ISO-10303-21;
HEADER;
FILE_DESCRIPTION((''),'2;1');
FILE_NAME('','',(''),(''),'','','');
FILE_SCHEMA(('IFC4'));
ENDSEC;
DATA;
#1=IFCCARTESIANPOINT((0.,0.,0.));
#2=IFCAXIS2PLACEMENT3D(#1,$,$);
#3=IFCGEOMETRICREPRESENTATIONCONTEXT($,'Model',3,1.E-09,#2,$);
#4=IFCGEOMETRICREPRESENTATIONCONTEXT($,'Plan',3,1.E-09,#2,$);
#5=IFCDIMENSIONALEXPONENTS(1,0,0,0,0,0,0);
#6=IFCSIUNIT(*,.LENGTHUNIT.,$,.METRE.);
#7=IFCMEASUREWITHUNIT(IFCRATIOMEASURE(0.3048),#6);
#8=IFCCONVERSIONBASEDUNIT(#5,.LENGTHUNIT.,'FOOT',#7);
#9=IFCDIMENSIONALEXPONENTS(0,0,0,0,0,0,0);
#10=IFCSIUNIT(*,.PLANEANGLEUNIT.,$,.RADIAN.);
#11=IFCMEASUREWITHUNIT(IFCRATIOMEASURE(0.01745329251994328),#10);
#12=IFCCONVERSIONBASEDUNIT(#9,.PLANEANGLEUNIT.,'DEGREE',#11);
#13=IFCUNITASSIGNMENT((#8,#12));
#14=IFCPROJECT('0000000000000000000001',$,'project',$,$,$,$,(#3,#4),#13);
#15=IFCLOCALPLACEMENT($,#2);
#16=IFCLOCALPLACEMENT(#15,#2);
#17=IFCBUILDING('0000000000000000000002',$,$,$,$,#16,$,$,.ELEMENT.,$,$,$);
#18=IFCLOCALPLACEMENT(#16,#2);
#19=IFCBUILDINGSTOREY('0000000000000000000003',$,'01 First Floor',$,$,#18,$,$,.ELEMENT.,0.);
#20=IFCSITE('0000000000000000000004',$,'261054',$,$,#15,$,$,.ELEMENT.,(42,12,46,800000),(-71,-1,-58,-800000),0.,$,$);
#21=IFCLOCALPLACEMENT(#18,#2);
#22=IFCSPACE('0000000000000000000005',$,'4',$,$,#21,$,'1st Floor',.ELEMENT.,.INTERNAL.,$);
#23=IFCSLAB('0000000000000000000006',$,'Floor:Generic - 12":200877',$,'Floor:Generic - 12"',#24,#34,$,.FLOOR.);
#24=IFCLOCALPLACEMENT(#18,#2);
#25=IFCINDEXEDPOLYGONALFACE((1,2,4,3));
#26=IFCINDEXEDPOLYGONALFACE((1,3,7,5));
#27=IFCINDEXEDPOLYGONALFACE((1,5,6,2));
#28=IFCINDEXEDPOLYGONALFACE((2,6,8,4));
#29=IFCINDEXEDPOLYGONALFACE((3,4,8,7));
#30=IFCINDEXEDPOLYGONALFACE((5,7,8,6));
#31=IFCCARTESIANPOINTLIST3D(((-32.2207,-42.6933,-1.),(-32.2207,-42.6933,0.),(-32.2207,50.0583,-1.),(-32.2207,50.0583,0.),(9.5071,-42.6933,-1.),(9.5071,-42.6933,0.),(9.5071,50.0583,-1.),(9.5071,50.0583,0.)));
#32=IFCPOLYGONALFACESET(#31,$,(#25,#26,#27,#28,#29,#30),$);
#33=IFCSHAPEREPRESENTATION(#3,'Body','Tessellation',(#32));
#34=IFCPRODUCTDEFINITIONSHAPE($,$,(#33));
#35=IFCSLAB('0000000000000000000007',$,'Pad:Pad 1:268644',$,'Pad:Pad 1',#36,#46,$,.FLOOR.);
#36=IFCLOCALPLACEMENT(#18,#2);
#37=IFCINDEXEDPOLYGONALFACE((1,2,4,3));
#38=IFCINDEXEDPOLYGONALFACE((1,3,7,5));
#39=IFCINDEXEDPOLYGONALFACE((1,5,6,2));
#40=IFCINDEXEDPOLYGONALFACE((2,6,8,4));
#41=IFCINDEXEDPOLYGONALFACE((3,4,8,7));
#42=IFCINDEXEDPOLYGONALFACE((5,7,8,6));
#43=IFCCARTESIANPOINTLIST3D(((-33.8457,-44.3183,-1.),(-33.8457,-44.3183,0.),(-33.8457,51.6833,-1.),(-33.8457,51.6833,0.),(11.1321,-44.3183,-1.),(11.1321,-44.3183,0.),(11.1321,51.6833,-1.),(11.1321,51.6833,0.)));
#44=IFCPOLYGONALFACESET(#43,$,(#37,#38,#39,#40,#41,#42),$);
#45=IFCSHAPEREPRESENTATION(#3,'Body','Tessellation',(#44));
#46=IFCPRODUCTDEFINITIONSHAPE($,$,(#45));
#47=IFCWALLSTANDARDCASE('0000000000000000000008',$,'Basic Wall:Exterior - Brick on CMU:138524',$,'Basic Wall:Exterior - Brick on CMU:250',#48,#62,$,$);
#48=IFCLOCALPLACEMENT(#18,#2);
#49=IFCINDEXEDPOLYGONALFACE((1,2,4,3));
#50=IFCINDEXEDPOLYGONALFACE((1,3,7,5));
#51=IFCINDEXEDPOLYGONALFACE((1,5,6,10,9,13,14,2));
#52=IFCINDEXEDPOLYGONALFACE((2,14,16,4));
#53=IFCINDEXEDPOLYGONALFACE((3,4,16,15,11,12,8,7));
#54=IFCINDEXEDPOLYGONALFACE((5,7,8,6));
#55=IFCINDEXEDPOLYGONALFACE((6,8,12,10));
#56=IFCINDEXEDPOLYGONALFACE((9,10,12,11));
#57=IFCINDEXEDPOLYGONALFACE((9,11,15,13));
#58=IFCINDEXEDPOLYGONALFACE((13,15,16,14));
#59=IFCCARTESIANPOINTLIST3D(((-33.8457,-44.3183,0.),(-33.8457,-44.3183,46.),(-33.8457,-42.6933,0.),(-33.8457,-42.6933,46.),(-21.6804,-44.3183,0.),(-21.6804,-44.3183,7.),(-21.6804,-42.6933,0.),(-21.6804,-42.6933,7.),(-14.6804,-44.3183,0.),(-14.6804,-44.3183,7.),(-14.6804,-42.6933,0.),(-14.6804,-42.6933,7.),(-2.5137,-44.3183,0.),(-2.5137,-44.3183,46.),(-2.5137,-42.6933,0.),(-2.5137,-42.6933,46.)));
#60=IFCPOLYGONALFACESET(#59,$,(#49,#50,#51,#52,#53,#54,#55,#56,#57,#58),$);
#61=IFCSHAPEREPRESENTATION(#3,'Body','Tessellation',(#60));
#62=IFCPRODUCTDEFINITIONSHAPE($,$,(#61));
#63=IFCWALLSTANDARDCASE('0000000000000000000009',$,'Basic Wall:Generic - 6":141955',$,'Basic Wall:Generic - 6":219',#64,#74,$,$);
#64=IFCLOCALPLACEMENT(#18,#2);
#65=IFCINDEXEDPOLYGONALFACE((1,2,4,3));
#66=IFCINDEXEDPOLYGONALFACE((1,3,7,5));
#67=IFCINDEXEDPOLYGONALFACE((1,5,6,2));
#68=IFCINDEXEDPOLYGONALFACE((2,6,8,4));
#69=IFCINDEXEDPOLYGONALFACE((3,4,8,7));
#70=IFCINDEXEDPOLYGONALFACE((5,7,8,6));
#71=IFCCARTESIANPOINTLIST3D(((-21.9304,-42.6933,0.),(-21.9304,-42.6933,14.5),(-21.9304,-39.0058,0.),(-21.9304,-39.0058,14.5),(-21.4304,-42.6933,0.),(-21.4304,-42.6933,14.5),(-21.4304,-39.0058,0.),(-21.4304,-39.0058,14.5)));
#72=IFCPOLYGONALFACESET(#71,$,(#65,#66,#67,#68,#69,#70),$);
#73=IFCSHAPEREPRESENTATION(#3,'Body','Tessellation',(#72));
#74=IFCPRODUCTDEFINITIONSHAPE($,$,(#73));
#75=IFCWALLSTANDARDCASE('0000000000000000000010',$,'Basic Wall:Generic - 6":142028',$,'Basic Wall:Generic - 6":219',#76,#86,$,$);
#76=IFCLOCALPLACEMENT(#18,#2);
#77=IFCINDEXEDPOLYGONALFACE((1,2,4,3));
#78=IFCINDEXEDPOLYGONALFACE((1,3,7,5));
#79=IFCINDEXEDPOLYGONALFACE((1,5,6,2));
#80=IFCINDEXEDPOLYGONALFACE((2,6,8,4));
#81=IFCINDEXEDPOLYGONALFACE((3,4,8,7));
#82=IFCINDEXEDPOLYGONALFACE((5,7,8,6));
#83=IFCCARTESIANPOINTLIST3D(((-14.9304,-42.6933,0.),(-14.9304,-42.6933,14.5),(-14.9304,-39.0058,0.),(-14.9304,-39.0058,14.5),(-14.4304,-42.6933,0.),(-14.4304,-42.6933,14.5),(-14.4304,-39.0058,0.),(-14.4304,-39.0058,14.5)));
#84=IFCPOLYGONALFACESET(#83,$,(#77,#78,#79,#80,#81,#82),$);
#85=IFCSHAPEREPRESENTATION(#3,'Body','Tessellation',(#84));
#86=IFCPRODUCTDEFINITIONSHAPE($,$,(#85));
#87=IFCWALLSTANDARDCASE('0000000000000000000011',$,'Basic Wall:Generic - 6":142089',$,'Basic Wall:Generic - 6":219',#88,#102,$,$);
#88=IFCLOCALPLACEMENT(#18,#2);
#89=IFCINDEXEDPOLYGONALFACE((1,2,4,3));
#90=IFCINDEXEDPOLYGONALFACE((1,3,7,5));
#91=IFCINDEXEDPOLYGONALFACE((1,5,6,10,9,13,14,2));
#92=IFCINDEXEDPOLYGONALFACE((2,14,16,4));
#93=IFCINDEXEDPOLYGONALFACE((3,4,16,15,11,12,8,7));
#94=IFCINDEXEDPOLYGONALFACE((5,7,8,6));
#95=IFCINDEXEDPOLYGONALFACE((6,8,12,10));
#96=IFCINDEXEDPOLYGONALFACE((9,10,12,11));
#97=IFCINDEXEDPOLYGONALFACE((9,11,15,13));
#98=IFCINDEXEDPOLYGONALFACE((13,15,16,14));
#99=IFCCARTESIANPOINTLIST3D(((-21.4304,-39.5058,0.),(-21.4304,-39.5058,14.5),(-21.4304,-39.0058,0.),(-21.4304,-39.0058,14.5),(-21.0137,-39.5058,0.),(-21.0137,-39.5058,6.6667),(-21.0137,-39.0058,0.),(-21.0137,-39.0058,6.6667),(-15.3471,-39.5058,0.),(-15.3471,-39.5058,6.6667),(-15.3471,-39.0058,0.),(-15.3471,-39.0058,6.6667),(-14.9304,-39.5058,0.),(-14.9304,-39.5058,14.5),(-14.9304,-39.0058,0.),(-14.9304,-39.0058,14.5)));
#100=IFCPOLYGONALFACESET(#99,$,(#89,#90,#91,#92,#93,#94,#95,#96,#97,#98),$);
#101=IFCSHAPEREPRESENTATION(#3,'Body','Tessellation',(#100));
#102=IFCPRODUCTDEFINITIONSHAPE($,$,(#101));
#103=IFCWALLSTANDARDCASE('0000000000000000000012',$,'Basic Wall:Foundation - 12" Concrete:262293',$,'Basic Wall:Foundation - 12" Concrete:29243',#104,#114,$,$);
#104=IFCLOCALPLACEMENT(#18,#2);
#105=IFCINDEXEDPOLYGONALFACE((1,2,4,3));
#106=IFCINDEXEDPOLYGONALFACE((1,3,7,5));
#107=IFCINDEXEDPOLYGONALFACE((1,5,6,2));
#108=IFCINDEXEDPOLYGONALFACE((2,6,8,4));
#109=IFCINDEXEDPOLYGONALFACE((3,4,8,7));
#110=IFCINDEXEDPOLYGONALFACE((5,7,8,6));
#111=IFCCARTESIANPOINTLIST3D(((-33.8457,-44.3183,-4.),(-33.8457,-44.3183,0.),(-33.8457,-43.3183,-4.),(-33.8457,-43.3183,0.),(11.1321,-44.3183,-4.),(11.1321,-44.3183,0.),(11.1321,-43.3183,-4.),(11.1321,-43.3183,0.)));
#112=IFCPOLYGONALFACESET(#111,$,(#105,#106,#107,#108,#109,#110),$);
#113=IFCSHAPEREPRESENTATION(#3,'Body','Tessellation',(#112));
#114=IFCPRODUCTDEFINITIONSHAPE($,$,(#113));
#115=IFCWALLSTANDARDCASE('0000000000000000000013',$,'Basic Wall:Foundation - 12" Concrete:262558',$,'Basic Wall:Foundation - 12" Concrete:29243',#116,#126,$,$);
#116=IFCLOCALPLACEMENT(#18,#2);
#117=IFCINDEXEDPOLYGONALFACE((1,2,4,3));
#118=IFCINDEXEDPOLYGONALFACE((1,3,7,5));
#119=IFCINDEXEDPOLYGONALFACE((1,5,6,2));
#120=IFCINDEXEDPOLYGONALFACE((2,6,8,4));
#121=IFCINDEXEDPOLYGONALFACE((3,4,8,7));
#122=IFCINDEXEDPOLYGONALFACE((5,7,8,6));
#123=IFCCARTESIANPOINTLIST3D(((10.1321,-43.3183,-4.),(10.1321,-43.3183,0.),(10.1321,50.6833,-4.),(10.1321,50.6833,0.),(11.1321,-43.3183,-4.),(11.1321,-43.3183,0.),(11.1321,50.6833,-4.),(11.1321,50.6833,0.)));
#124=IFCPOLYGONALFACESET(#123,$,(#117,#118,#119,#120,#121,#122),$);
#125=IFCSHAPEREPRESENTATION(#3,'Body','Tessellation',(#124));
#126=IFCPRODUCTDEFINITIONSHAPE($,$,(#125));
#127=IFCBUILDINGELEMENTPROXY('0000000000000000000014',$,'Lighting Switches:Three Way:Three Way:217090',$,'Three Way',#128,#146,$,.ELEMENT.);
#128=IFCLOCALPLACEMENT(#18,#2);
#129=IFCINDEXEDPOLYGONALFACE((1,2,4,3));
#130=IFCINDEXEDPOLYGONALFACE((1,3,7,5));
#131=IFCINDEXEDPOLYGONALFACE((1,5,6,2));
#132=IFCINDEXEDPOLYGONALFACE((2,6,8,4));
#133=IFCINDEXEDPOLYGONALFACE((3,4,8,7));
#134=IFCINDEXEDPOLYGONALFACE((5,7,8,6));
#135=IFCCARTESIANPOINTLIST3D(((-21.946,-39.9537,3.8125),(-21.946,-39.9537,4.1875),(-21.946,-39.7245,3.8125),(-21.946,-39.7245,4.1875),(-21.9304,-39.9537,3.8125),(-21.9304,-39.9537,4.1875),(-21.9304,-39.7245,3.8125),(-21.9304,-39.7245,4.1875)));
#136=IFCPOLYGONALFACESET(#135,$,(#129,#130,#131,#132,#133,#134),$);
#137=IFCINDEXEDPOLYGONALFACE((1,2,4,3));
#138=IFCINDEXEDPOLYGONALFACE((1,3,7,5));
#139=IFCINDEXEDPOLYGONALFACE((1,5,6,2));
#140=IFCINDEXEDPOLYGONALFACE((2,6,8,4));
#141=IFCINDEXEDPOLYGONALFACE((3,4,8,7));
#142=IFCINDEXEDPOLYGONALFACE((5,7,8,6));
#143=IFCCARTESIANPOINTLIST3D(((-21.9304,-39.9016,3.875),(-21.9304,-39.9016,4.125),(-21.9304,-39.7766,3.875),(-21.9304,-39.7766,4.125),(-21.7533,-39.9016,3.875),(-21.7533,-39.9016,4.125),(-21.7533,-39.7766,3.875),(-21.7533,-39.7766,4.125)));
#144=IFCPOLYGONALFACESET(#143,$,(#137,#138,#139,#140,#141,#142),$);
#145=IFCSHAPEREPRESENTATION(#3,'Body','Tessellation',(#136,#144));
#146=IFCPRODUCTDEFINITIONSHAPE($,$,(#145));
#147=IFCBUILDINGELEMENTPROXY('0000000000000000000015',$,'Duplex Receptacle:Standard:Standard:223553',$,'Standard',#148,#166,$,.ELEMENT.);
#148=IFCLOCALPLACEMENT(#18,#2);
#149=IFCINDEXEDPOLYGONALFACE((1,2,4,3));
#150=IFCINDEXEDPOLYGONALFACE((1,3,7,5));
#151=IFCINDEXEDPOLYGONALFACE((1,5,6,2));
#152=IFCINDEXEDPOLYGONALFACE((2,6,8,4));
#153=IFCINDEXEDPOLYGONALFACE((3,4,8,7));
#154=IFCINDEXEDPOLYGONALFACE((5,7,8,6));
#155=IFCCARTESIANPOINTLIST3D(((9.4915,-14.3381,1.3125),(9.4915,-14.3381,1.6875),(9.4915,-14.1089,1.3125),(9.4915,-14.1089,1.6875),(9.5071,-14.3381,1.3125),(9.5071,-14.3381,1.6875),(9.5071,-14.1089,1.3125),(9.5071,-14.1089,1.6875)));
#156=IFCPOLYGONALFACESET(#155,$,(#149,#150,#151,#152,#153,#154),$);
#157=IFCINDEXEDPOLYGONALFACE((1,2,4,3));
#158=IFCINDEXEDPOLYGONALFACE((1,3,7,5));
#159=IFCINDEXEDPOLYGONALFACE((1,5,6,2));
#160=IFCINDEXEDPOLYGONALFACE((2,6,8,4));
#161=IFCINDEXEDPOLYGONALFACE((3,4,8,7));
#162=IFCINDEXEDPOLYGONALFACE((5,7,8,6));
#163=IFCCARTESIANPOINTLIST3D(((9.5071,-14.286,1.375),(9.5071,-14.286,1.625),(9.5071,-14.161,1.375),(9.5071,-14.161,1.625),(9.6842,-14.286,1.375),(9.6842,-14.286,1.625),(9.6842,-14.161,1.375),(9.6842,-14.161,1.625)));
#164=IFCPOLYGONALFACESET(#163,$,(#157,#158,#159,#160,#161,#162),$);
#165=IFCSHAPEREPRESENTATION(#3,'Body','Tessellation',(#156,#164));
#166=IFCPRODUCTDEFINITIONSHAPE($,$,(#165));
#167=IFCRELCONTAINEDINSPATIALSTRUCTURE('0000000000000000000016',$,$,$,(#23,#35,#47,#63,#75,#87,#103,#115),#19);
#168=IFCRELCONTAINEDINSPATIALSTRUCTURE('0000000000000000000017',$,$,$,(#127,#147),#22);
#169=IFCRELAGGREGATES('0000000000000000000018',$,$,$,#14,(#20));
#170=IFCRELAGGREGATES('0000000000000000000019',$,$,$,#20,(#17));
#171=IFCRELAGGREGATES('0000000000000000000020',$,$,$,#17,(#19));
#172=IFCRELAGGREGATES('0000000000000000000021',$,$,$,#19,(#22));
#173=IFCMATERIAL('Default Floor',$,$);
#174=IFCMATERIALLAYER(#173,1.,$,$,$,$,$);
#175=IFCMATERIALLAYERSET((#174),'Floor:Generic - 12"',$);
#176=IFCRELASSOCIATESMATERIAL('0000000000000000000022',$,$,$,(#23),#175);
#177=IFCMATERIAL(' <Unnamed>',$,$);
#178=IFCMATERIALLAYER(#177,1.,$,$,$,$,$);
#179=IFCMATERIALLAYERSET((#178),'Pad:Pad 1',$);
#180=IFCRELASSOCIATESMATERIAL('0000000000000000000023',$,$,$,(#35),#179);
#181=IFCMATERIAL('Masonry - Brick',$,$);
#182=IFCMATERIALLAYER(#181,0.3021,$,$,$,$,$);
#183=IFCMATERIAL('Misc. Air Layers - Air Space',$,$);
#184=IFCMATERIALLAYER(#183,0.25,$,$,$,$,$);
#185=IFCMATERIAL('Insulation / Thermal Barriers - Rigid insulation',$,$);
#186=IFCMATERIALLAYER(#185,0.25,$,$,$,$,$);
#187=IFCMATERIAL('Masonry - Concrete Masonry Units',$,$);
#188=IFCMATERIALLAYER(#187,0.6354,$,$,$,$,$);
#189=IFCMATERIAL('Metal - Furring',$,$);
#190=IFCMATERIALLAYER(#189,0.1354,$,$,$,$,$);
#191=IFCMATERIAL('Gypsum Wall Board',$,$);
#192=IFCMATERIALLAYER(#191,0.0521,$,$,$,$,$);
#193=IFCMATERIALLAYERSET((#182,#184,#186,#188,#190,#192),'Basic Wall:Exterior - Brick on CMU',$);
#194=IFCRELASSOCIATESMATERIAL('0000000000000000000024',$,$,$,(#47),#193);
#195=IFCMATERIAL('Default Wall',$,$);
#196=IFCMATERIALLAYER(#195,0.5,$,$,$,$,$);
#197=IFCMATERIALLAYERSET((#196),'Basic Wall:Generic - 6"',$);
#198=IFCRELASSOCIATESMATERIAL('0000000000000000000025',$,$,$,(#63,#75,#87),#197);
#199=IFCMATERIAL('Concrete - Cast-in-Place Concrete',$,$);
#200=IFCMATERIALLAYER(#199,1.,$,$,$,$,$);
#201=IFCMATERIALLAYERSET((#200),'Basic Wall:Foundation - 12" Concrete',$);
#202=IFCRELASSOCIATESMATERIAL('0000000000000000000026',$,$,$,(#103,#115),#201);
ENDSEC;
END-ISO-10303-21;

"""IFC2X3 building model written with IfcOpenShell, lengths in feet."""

from ifc_helpers import new_model, entity, si_unit, converted_unit, frame, frame_2d, origin, origin_2d_with_axis, place, context, project, spatial, polyline, rectangle, extrude, clip, bounded_halfspace, source, transform, mapped, material, layer, layer_set, layer_usage, element, save


model = new_model("IFC2X3")

# Units and contexts
model_context = context("Model", 3, precision=1e-09, world=origin())
plan_context = context("Plan", 3, precision=1e-09, world=origin())
ifc_project = project(units=[converted_unit("LENGTHUNIT", "FOOT", entity("IfcRatioMeasure", 0.3048), si_unit("LENGTHUNIT", "METRE"), dimensions=[1, 0, 0, 0, 0, 0, 0]), converted_unit("PLANEANGLEUNIT", "DEGREE", entity("IfcRatioMeasure", 0.01745329251994328), si_unit("PLANEANGLEUNIT", "RADIAN"), dimensions=[0, 0, 0, 0, 0, 0, 0])], contexts=[model_context, plan_context])

# Site, building, storey
site_placement = place(None, origin())
site = spatial("IfcSite", under=ifc_project, at=site_placement, Name="261054", CompositionType="ELEMENT", RefLatitude=(42, 12, 46, 800000), RefLongitude=(-71, -1, -58, -800000), RefElevation=0.0)
building_placement = place(site_placement, origin())
building = spatial("IfcBuilding", under=site, at=building_placement, CompositionType="ELEMENT")
storey_placement = place(building_placement, origin())
storey = spatial("IfcBuildingStorey", under=building, at=storey_placement, Name="01 First Floor", CompositionType="ELEMENT", Elevation=0.0)

# Slabs
ifc_material_1 = material(Name="Default Floor")
ifc_layer_1 = layer(ifc_material_1, 1.0)
ifc_layer_set_1 = layer_set([ifc_layer_1], Name="Floor:Generic - 12\"")
ifc_layer_usage_1 = layer_usage(ifc_layer_set_1, "AXIS3", "POSITIVE", 0.0)
slab_1_placement = place(storey_placement, frame((-32.2207, -42.6933, -1.0)))
element("IfcSlab", 1, at=slab_1_placement, inside=storey, material=ifc_layer_usage_1, Name="Floor:Generic - 12\":200877", ObjectType="Floor:Generic - 12\"", PredefinedType="FLOOR", context=model_context, shape_type="SweptSolid", body=[
    extrude(rectangle(XDim=92.7515, YDim=41.7278, at=frame_2d((0.0, 0.0), x_axis=(0.0, 1.0))), frame((20.8639, 46.3758, 1.0), z_axis=(0.0, 0.0, -1.0), x_axis=(-1.0, 0.0, 0.0)), (0.0, 0.0, 1.0), 1.0),
])
ifc_material_2 = material(Name=" <Unnamed>")
ifc_layer_2 = layer(ifc_material_2, 1.0)
ifc_layer_set_2 = layer_set([ifc_layer_2], Name="Pad:Pad 1")
ifc_layer_usage_2 = layer_usage(ifc_layer_set_2, "AXIS3", "NEGATIVE", 0.0)
slab_2_placement = place(storey_placement, frame((-33.8457, -44.3183, -1.0)))
element("IfcSlab", 2, at=slab_2_placement, inside=storey, material=ifc_layer_usage_2, Name="Pad:Pad 1:268644", ObjectType="Pad:Pad 1", PredefinedType="FLOOR", context=model_context, shape_type="SweptSolid", body=[
    extrude(rectangle(XDim=96.0015, YDim=44.9778, at=frame_2d((0.0, 0.0), x_axis=(0.0, 1.0))), frame((22.4889, 48.0008, 1.0), z_axis=(0.0, 0.0, -1.0), x_axis=(-1.0, 0.0, 0.0)), (0.0, 0.0, 1.0), 1.0),
])

# Wall, opening
ifc_material_3 = material(Name="Masonry - Brick")
ifc_layer_3 = layer(ifc_material_3, 0.3021)
ifc_material_4 = material(Name="Misc. Air Layers - Air Space")
ifc_layer_4 = layer(ifc_material_4, 0.25)
ifc_material_5 = material(Name="Insulation / Thermal Barriers - Rigid insulation")
ifc_layer_5 = layer(ifc_material_5, 0.25)
ifc_material_6 = material(Name="Masonry - Concrete Masonry Units")
ifc_layer_6 = layer(ifc_material_6, 0.6354)
ifc_material_7 = material(Name="Metal - Furring")
ifc_layer_7 = layer(ifc_material_7, 0.1354)
ifc_material_8 = material(Name="Gypsum Wall Board")
ifc_layer_8 = layer(ifc_material_8, 0.0521)
ifc_layer_set_3 = layer_set([ifc_layer_3, ifc_layer_4, ifc_layer_5, ifc_layer_6, ifc_layer_7, ifc_layer_8], Name="Basic Wall:Exterior - Brick on CMU")
ifc_layer_usage_3 = layer_usage(ifc_layer_set_3, "AXIS2", "POSITIVE", -0.8125)
wall_1_placement = place(storey_placement, frame((-33.8457, -43.5058, 0.0)))
wall_1 = element("IfcWallStandardCase", 3, at=wall_1_placement, inside=storey, material=ifc_layer_usage_3, Name="Basic Wall:Exterior - Brick on CMU:138524", ObjectType="Basic Wall:Exterior - Brick on CMU:250", context=model_context, shape_type="SweptSolid", body=[
    extrude(rectangle(XDim=31.332, YDim=1.625, at=frame_2d((15.666, 0.0), x_axis=(-1.0, 0.0))), origin(), (0.0, 0.0, 1.0), 46.0),
])
opening_1_placement = place(wall_1_placement, origin())
element("IfcOpeningElement", 4, at=opening_1_placement, cuts=wall_1, ObjectType="Opening", context=model_context, shape_type="SweptSolid", body=[
    extrude(rectangle(XDim=7.0, YDim=7.0, at=origin_2d_with_axis()), frame((15.6653, -0.8125, 3.5), z_axis=(0.0, 1.0, 0.0), x_axis=(0.0, 0.0, -1.0)), (0.0, 0.0, 1.0), 1.625),
])

# Walls
ifc_material_9 = material(Name="Default Wall")
ifc_layer_9 = layer(ifc_material_9, 0.5)
ifc_layer_set_4 = layer_set([ifc_layer_9], Name="Basic Wall:Generic - 6\"")
ifc_layer_usage_4 = layer_usage(ifc_layer_set_4, "AXIS2", "NEGATIVE", 0.25)
wall_2_placement = place(storey_placement, frame((-21.6804, -42.6933, 0.0), z_axis=(0.0, 0.0, 1.0), x_axis=(0.0, 1.0, 0.0)))
element("IfcWallStandardCase", 5, at=wall_2_placement, inside=storey, material=ifc_layer_usage_4, Name="Basic Wall:Generic - 6\":141955", ObjectType="Basic Wall:Generic - 6\":219", context=model_context, shape_type="Clipping", body=[
    clip(extrude(rectangle(XDim=3.6875, YDim=0.5, at=frame_2d((1.8438, 0.0), x_axis=(-1.0, 0.0))), origin(), (0.0, 0.0, 1.0), 14.5), bounded_halfspace(frame((0.0, -0.25, 14.5), z_axis=(0.0, 0.0, -1.0), x_axis=(-1.0, 0.0, 0.0)), True, frame((0.0, -0.25, 14.5)), polyline([(0.0, 0.0), (3.1875, 0.0), (3.6875, 0.0), (3.6875, 0.5), (0.0, 0.5), (0.0, 0.0)]))),
])
ifc_layer_usage_5 = layer_usage(ifc_layer_set_4, "AXIS2", "NEGATIVE", 0.25)
wall_3_placement = place(storey_placement, frame((-14.6804, -39.0058, 0.0), z_axis=(0.0, 0.0, 1.0), x_axis=(0.0, -1.0, 0.0)))
element("IfcWallStandardCase", 6, at=wall_3_placement, inside=storey, material=ifc_layer_usage_5, Name="Basic Wall:Generic - 6\":142028", ObjectType="Basic Wall:Generic - 6\":219", context=model_context, shape_type="Clipping", body=[
    clip(extrude(rectangle(XDim=3.6875, YDim=0.5, at=frame_2d((1.8438, 0.0), x_axis=(-1.0, 0.0))), origin(), (0.0, 0.0, 1.0), 14.5), bounded_halfspace(frame((0.0, -0.25, 14.5), z_axis=(0.0, 0.0, -1.0), x_axis=(1.0, 0.0, 0.0)), True, frame((0.0, -0.25, 14.5)), polyline([(0.0, 0.0), (0.5, 0.0), (3.6875, 0.0), (3.6875, 0.5), (0.0, 0.5), (0.0, 0.0)]))),
])

# Wall, opening
ifc_layer_usage_6 = layer_usage(ifc_layer_set_4, "AXIS2", "NEGATIVE", 0.25)
wall_4_placement = place(storey_placement, frame((-21.4304, -39.2558, 0.0)))
wall_4 = element("IfcWallStandardCase", 7, at=wall_4_placement, inside=storey, material=ifc_layer_usage_6, Name="Basic Wall:Generic - 6\":142089", ObjectType="Basic Wall:Generic - 6\":219", context=model_context, shape_type="Clipping", body=[
    clip(extrude(rectangle(XDim=6.5, YDim=0.5, at=frame_2d((3.25, 0.0), x_axis=(-1.0, 0.0))), origin(), (0.0, 0.0, 1.0), 14.5), bounded_halfspace(frame((0.0, -0.25, 14.5), z_axis=(0.0, 0.0, -1.0), x_axis=(0.0, -1.0, 0.0)), True, frame((0.0, -0.25, 14.5)), polyline([(0.0, 0.0), (6.5, 0.0), (6.5, 0.5), (0.0, 0.5), (0.0, 0.0)]))),
])
opening_2_placement = place(wall_4_placement, frame((6.0833, 0.25, 0.0)))
element("IfcOpeningElement", 8, at=opening_2_placement, cuts=wall_4, ObjectType="Opening", context=model_context, shape_type="SweptSolid", body=[
    extrude(rectangle(XDim=6.6667, YDim=5.6667, at=frame_2d((3.3333, 2.8333), x_axis=(1.0, 0.0))), frame((0.0, 0.0, 0.0), z_axis=(0.0, -1.0, 0.0), x_axis=(0.0, 0.0, 1.0)), (0.0, 0.0, 1.0), 0.5),
])

# Walls
ifc_material_10 = material(Name="Concrete - Cast-in-Place Concrete")
ifc_layer_10 = layer(ifc_material_10, 1.0)
ifc_layer_set_5 = layer_set([ifc_layer_10], Name="Basic Wall:Foundation - 12\" Concrete")
ifc_layer_usage_7 = layer_usage(ifc_layer_set_5, "AXIS2", "NEGATIVE", 0.5)
wall_5_placement = place(storey_placement, frame((11.1321, -43.8183, -4.0), z_axis=(0.0, 0.0, 1.0), x_axis=(-1.0, 0.0, 0.0)))
element("IfcWallStandardCase", 9, at=wall_5_placement, inside=storey, material=ifc_layer_usage_7, Name="Basic Wall:Foundation - 12\" Concrete:262293", ObjectType="Basic Wall:Foundation - 12\" Concrete:29243", context=model_context, shape_type="SweptSolid", body=[
    extrude(rectangle(XDim=44.9778, YDim=1.0, at=frame_2d((22.4889, 0.0), x_axis=(-1.0, 0.0))), origin(), (0.0, 0.0, 1.0), 4.0),
])
ifc_layer_usage_8 = layer_usage(ifc_layer_set_5, "AXIS2", "NEGATIVE", 0.5)
wall_6_placement = place(storey_placement, frame((10.6321, -43.3183, -4.0), z_axis=(0.0, 0.0, 1.0), x_axis=(0.0, 1.0, 0.0)))
element("IfcWallStandardCase", 10, at=wall_6_placement, inside=storey, material=ifc_layer_usage_8, Name="Basic Wall:Foundation - 12\" Concrete:262558", ObjectType="Basic Wall:Foundation - 12\" Concrete:29243", context=model_context, shape_type="SweptSolid", body=[
    extrude(rectangle(XDim=94.0015, YDim=1.0, at=frame_2d((47.0008, 0.0), x_axis=(-1.0, 0.0))), origin(), (0.0, 0.0, 1.0), 4.0),
])

# Shared definitions
space_placement = place(storey_placement, origin())
space = spatial("IfcSpace", under=storey, at=space_placement, Name="4", LongName="1st Floor", CompositionType="ELEMENT", InteriorOrExteriorSpace="INTERNAL")

# Building element proxies
shared_shape_1 = source(origin(), model_context, "Body", "SweptSolid", [
    extrude(rectangle(XDim=0.2292, YDim=0.375, at=origin_2d_with_axis()), frame((0.0, 0.0, 0.0), z_axis=(0.0, 0.0, 1.0), x_axis=(-1.0, 0.0, 0.0)), (0.0, 0.0, 1.0), 0.0156),
    extrude(rectangle(XDim=0.125, YDim=0.25, at=origin_2d_with_axis()), frame((0.0, 0.0, -0.1771), z_axis=(0.0, 0.0, 1.0), x_axis=(-1.0, 0.0, 0.0)), (0.0, 0.0, 1.0), 0.1771),
])
proxy_1_placement = place(space_placement, frame((-21.9304, -39.8391, 4.0), z_axis=(-1.0, 0.0, 0.0), x_axis=(0.0, -1.0, 0.0)))
element("IfcBuildingElementProxy", 11, at=proxy_1_placement, inside=space, Name="Lighting Switches:Three Way:Three Way:217090", ObjectType="Three Way", CompositionType="ELEMENT", context=model_context, shape_type="MappedRepresentation", body=[
    mapped(shared_shape_1, transform((0.0, 0.0, 0.0), scale=1.0)),
])
shared_shape_2 = source(origin(), model_context, "Body", "SweptSolid", [
    extrude(rectangle(XDim=0.2292, YDim=0.375, at=origin_2d_with_axis()), frame((0.0, 0.0, 0.0), z_axis=(0.0, 0.0, 1.0), x_axis=(-1.0, 0.0, 0.0)), (0.0, 0.0, 1.0), 0.0156),
    extrude(rectangle(XDim=0.125, YDim=0.25, at=origin_2d_with_axis()), frame((0.0, 0.0, -0.1771), z_axis=(0.0, 0.0, 1.0), x_axis=(-1.0, 0.0, 0.0)), (0.0, 0.0, 1.0), 0.1771),
])
for number, where, z_axis, x_axis, name in (
    (12, (9.5071, -14.2235, 1.5), (-1.0, 0.0, 0.0), (0.0, -1.0, 0.0), "Duplex Receptacle:Standard:Standard:223553"),
):
    element("IfcBuildingElementProxy", number, at=place(space_placement, frame(where, z_axis=z_axis, x_axis=x_axis)), inside=space, Name=name, ObjectType="Standard", CompositionType="ELEMENT", context=model_context, shape_type="MappedRepresentation", body=[
        mapped(shared_shape_2, transform((0.0, 0.0, 0.0), scale=1.0)),
    ])

save(model, "model.ifc")
